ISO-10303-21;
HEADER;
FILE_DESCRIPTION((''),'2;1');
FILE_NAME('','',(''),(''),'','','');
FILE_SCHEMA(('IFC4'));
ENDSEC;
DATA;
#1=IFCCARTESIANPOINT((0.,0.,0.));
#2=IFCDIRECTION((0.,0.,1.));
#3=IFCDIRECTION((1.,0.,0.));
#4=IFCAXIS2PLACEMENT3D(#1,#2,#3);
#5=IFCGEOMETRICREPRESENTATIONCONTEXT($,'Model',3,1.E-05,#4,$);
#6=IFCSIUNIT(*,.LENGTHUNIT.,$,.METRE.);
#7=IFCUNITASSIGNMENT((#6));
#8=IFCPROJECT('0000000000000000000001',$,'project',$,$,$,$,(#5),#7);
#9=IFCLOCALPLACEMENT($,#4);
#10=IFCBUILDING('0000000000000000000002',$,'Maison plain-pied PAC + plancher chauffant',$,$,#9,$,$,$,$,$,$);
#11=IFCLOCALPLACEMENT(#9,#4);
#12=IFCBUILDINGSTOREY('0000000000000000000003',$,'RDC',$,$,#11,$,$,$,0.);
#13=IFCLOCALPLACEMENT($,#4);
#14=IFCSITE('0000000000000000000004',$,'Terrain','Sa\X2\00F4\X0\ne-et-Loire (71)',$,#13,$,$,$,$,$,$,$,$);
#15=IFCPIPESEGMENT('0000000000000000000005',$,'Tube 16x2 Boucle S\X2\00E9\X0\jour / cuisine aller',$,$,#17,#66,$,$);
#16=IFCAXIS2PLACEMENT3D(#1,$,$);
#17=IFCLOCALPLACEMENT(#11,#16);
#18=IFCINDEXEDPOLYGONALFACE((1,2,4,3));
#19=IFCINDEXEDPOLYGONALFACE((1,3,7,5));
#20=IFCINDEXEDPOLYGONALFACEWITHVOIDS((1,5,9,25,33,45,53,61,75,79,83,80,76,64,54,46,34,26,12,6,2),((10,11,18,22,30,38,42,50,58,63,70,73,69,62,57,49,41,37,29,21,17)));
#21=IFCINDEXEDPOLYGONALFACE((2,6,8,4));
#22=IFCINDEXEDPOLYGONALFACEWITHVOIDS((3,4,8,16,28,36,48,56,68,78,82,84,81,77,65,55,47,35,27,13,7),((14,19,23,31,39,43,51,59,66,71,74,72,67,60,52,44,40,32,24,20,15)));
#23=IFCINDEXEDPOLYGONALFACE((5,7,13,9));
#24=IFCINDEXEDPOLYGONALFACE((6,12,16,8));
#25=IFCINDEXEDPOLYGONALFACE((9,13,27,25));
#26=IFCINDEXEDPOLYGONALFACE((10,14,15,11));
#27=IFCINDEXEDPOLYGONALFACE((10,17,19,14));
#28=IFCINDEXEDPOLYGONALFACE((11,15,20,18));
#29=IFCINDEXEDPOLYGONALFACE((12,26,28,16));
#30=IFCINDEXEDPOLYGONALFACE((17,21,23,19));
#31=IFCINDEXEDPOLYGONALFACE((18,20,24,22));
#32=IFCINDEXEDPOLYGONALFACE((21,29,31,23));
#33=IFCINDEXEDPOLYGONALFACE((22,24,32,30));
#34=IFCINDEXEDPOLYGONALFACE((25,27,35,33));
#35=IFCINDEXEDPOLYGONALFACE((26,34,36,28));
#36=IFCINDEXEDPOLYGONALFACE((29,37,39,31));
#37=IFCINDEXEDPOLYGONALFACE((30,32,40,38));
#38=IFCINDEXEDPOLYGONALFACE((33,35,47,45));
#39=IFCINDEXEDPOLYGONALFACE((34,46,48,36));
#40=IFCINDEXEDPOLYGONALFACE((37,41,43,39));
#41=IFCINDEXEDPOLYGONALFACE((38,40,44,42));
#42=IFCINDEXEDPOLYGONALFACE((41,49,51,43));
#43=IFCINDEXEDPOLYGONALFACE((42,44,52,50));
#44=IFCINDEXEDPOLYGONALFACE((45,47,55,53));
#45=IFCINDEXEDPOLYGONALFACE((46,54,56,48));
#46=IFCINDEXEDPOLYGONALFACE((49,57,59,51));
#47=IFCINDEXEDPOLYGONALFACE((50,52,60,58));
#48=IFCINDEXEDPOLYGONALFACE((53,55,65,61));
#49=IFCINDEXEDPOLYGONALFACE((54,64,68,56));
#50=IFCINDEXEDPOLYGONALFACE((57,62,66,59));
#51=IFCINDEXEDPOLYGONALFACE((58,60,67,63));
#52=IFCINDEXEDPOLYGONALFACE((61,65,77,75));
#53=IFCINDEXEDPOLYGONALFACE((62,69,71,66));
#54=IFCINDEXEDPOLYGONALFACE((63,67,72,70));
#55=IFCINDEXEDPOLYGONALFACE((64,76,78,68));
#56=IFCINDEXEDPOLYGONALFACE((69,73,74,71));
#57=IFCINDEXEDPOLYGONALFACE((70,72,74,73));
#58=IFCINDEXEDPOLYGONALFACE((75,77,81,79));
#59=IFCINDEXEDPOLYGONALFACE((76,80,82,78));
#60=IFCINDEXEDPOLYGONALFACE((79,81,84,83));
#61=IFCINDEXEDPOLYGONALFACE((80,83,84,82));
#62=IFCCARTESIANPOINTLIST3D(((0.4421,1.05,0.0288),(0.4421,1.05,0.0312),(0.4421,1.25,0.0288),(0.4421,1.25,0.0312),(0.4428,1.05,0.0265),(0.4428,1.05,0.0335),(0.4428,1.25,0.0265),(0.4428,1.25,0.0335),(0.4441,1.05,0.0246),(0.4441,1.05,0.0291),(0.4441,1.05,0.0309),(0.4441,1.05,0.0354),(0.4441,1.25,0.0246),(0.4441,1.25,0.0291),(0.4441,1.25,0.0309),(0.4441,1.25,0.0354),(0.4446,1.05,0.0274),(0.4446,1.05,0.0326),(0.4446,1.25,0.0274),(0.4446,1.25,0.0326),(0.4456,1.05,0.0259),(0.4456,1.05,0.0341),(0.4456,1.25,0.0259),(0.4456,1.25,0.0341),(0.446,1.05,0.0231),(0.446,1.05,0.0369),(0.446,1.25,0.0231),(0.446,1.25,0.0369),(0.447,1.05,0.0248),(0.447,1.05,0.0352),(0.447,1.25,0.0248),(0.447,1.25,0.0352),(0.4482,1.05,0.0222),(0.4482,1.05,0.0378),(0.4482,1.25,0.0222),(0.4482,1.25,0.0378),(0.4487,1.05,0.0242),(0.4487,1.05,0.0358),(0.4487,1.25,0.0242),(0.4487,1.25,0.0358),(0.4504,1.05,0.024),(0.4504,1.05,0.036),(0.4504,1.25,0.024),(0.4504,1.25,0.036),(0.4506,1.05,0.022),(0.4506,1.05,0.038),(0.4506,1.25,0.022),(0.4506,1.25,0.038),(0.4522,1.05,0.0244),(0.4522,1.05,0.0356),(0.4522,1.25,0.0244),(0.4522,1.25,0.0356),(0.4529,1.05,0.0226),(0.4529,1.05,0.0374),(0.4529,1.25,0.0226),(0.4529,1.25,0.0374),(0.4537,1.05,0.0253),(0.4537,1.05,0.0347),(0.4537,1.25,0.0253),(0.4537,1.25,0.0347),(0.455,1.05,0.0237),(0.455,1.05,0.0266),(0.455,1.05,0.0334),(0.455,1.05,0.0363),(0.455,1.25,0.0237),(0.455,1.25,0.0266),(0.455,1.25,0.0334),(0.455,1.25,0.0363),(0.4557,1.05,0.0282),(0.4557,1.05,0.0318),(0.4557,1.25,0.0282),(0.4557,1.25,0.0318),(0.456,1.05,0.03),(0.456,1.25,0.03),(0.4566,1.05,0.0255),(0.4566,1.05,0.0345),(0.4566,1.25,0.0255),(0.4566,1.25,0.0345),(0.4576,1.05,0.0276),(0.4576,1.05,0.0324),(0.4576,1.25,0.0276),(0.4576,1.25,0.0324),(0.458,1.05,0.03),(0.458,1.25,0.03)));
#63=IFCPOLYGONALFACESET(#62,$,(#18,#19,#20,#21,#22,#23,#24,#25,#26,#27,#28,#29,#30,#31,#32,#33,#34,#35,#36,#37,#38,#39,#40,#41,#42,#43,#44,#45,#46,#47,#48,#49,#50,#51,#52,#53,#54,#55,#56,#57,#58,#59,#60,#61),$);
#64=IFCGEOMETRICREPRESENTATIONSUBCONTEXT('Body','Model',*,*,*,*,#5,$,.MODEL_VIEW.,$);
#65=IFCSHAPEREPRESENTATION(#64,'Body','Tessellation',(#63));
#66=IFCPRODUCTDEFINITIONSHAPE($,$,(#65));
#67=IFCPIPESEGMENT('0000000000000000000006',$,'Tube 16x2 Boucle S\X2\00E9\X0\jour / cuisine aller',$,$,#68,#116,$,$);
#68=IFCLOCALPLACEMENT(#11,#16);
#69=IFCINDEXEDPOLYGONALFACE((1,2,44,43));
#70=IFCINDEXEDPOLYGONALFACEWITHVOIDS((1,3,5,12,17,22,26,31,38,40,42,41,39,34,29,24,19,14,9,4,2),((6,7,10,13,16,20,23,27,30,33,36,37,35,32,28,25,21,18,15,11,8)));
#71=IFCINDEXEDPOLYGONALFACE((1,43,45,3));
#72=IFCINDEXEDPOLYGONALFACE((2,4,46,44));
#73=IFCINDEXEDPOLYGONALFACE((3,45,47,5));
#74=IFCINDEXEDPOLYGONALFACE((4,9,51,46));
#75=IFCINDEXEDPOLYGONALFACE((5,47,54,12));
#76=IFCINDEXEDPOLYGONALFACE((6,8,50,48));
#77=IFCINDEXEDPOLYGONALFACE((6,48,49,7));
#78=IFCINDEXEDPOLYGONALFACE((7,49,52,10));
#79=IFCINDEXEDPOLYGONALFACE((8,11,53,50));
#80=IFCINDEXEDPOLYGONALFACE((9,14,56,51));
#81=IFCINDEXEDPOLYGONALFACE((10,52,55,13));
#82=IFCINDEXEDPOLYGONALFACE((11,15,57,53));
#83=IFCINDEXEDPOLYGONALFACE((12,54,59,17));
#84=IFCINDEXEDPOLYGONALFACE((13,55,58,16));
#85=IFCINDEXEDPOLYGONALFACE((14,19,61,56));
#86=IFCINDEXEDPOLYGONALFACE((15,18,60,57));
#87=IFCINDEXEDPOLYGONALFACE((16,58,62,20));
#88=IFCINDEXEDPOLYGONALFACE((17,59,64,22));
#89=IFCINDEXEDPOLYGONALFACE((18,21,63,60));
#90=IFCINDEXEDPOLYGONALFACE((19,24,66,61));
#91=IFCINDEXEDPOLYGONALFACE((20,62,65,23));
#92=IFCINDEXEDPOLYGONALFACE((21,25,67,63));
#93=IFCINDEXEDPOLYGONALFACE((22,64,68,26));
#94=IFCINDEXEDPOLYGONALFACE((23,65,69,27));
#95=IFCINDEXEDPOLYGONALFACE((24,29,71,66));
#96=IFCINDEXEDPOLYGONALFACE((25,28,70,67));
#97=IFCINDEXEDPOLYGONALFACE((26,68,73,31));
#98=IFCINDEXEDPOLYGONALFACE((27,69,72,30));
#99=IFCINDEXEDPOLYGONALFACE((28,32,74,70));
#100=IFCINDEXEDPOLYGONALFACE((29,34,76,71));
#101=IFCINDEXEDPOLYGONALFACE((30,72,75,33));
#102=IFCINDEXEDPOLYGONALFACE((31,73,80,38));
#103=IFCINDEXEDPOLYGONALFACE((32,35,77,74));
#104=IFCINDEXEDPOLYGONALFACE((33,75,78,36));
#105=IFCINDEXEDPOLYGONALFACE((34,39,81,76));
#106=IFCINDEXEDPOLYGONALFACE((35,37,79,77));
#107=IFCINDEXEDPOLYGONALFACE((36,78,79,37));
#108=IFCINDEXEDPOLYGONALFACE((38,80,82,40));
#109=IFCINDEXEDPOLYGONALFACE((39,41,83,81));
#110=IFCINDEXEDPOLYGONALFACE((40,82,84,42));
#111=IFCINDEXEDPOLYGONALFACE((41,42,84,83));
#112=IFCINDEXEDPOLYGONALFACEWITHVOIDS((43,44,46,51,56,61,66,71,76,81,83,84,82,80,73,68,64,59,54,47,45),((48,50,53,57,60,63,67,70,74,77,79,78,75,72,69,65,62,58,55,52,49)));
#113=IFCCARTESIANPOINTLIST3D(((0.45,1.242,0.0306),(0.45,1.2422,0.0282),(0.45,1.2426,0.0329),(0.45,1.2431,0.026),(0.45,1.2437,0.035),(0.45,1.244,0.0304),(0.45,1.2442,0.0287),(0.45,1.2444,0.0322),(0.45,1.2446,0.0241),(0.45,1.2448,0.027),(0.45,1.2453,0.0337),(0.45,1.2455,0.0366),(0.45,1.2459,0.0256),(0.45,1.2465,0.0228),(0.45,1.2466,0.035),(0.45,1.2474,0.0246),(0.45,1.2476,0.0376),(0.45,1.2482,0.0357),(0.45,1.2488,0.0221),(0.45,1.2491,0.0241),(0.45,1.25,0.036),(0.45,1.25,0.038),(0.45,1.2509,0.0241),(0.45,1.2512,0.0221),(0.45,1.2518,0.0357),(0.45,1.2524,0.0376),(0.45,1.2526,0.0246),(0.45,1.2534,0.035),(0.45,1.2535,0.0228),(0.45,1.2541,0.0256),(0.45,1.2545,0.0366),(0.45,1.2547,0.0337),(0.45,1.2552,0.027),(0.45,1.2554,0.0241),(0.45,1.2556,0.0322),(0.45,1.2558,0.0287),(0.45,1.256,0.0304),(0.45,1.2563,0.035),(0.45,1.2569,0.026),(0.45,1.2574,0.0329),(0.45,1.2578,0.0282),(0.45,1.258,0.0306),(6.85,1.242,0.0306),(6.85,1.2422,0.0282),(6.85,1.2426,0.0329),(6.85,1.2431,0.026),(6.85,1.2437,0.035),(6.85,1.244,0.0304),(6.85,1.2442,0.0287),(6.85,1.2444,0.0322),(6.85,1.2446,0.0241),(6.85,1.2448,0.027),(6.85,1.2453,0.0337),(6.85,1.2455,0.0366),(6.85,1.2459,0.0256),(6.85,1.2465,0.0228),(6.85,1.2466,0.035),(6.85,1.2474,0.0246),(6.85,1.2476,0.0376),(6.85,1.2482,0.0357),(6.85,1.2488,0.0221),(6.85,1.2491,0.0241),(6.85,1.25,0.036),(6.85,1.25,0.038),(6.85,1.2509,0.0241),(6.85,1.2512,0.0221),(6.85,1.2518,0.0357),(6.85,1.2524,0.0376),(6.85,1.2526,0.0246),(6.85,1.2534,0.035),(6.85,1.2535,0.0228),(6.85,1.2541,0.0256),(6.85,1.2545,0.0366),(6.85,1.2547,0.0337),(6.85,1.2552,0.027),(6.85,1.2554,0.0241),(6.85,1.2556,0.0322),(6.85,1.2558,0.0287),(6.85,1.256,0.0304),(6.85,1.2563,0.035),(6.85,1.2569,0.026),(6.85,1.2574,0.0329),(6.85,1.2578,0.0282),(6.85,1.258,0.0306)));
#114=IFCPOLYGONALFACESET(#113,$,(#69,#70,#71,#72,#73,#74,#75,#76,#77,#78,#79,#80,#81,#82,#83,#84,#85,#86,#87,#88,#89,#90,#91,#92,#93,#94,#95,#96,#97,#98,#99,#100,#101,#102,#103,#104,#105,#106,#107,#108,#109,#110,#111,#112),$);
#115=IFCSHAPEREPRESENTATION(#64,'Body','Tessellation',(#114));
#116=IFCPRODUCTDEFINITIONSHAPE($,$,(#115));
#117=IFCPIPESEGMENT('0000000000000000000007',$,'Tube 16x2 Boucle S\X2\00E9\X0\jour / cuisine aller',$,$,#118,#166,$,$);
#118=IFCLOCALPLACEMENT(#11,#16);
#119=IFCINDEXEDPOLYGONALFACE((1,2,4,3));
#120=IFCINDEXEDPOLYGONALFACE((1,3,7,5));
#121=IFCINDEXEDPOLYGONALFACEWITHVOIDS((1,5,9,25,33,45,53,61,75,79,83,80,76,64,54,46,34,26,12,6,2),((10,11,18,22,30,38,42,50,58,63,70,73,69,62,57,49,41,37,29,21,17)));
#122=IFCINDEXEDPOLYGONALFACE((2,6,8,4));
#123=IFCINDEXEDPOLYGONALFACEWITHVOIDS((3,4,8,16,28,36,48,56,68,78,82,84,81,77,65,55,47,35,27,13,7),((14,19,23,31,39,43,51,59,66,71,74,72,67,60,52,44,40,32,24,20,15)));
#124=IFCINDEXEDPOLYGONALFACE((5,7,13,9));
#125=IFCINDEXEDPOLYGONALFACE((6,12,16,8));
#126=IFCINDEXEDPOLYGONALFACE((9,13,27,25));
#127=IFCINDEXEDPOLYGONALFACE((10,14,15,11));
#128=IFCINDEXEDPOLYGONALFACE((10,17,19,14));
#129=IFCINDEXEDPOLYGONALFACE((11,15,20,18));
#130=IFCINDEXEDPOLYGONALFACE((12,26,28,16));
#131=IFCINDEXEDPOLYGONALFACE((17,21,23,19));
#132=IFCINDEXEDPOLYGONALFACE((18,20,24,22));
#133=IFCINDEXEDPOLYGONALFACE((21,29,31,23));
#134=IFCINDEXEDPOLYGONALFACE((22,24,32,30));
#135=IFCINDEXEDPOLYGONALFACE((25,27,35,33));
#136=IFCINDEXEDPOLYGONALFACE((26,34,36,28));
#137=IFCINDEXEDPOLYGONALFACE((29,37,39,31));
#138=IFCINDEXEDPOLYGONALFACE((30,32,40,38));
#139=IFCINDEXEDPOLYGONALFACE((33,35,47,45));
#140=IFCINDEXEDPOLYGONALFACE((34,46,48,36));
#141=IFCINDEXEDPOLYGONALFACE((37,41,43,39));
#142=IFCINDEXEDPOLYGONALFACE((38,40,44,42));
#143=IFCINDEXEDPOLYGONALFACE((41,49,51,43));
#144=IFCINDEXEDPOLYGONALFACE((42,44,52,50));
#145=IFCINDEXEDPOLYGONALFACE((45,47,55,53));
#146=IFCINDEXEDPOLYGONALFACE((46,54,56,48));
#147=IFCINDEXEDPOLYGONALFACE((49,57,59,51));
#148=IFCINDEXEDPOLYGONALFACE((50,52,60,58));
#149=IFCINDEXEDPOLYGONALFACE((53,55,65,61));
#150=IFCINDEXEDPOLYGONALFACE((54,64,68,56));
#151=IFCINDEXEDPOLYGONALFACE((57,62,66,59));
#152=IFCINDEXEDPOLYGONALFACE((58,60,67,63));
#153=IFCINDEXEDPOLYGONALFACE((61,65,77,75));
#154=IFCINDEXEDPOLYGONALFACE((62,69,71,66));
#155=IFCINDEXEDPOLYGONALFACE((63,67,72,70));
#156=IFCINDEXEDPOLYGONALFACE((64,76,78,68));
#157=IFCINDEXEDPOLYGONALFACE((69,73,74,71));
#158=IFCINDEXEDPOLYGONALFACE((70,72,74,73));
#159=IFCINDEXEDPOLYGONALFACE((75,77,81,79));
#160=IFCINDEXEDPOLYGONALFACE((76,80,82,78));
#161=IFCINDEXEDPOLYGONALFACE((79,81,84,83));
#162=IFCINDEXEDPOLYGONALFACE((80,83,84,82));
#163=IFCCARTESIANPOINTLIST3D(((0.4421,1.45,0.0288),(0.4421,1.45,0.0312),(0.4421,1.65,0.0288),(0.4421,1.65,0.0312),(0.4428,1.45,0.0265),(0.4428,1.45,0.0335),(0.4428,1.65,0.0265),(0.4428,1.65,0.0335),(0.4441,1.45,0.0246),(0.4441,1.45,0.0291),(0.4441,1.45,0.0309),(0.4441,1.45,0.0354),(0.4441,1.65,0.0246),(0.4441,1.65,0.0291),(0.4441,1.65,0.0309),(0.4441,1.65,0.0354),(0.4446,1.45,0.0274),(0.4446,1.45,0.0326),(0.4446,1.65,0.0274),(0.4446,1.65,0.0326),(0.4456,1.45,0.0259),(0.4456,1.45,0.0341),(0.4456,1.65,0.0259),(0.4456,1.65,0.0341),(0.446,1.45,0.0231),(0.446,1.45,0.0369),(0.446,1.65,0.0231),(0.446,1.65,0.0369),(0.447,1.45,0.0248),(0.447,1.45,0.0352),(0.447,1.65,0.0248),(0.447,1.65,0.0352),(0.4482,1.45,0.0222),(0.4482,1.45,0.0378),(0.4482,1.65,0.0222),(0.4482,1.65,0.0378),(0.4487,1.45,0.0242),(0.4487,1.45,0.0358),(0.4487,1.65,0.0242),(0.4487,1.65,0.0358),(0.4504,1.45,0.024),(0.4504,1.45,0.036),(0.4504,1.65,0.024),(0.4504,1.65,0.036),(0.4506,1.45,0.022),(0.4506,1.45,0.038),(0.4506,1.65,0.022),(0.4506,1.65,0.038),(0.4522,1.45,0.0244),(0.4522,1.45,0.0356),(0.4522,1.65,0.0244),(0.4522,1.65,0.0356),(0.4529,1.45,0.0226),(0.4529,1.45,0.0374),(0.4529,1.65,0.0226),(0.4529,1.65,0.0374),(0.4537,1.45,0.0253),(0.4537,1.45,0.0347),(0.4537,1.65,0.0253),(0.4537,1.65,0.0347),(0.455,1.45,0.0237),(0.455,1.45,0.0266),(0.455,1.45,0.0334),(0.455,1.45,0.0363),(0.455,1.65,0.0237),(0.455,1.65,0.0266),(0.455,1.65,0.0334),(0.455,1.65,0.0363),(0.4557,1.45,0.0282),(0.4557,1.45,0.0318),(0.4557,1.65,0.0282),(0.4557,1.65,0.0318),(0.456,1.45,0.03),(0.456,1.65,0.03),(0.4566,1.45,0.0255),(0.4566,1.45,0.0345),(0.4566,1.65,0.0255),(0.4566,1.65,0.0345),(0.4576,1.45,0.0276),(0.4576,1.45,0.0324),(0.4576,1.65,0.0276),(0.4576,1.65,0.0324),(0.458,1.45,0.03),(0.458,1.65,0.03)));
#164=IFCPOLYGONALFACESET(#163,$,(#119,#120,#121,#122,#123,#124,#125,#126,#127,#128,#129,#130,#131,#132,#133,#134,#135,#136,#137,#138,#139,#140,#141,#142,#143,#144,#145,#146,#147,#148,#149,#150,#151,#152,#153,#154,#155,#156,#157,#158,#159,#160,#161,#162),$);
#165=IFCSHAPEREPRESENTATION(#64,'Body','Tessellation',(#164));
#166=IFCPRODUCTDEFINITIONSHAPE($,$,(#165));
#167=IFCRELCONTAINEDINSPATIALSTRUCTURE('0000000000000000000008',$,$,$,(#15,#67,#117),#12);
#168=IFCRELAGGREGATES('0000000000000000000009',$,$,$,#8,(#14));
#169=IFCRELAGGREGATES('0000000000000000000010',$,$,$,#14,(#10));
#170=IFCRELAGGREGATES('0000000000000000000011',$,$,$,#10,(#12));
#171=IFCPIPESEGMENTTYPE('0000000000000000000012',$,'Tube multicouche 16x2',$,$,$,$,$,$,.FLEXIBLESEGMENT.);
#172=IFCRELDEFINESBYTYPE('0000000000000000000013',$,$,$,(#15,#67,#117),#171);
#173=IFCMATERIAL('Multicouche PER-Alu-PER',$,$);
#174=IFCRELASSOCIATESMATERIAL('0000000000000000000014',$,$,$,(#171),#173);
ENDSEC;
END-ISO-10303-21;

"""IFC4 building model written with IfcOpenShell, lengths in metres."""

from ifc_helpers import new_model, si_unit, frame, origin_with_axes, place, context, subcontext, project, spatial, hollow_circle, extrude, material, type_object, element, save


model = new_model("IFC4")

# Units and contexts
model_context = context("Model", 3, precision=1e-05, world=origin_with_axes())
body_context = subcontext(model_context, "Body", "Model", "MODEL_VIEW")
ifc_project = project(units=[si_unit("LENGTHUNIT", "METRE")], contexts=[model_context])

# Site, building, storey
site_placement = place(None, origin_with_axes())
site = spatial("IfcSite", under=ifc_project, at=site_placement, Name="Terrain", Description="Saône-et-Loire (71)")
building_placement = place(None, origin_with_axes())
building = spatial("IfcBuilding", under=site, at=building_placement, Name="Maison plain-pied PAC + plancher chauffant")
storey_placement = place(building_placement, origin_with_axes())
storey = spatial("IfcBuildingStorey", under=building, at=storey_placement, Name="RDC", Elevation=0.0)

# Pipe segments
ifc_material_1 = material(Name="Multicouche PER-Alu-PER")
pipe_segment_type = type_object("IfcPipeSegmentType", Name="Tube multicouche 16x2", PredefinedType="FLEXIBLESEGMENT", material=ifc_material_1)
pipe_segment_1_placement = place(storey_placement, frame((0.45, 1.05, 0.03), z_axis=(0.0, 1.0, 0.0), x_axis=(1.0, 0.0, 0.0)))
element("IfcPipeSegment", 1, at=pipe_segment_1_placement, inside=storey, type_object=pipe_segment_type, Name="Tube 16x2 Boucle Séjour / cuisine aller", context=body_context, shape_type="SweptSolid", body=[
    extrude(hollow_circle(Radius=0.008, WallThickness=0.002), origin_with_axes(), (0.0, 0.0, 1.0), 0.2),
])
pipe_segment_2_placement = place(storey_placement, frame((0.45, 1.25, 0.03), z_axis=(1.0, 0.0, 0.0), x_axis=(0.0, 0.0, 1.0)))
element("IfcPipeSegment", 2, at=pipe_segment_2_placement, inside=storey, type_object=pipe_segment_type, Name="Tube 16x2 Boucle Séjour / cuisine aller", context=body_context, shape_type="SweptSolid", body=[
    extrude(hollow_circle(Radius=0.008, WallThickness=0.002), origin_with_axes(), (0.0, 0.0, 1.0), 6.4),
])
pipe_segment_3_placement = place(storey_placement, frame((0.45, 1.45, 0.03), z_axis=(0.0, 1.0, 0.0), x_axis=(1.0, 0.0, 0.0)))
element("IfcPipeSegment", 3, at=pipe_segment_3_placement, inside=storey, type_object=pipe_segment_type, Name="Tube 16x2 Boucle Séjour / cuisine aller", context=body_context, shape_type="SweptSolid", body=[
    extrude(hollow_circle(Radius=0.008, WallThickness=0.002), origin_with_axes(), (0.0, 0.0, 1.0), 0.2),
])

save(model, "model.ifc")
